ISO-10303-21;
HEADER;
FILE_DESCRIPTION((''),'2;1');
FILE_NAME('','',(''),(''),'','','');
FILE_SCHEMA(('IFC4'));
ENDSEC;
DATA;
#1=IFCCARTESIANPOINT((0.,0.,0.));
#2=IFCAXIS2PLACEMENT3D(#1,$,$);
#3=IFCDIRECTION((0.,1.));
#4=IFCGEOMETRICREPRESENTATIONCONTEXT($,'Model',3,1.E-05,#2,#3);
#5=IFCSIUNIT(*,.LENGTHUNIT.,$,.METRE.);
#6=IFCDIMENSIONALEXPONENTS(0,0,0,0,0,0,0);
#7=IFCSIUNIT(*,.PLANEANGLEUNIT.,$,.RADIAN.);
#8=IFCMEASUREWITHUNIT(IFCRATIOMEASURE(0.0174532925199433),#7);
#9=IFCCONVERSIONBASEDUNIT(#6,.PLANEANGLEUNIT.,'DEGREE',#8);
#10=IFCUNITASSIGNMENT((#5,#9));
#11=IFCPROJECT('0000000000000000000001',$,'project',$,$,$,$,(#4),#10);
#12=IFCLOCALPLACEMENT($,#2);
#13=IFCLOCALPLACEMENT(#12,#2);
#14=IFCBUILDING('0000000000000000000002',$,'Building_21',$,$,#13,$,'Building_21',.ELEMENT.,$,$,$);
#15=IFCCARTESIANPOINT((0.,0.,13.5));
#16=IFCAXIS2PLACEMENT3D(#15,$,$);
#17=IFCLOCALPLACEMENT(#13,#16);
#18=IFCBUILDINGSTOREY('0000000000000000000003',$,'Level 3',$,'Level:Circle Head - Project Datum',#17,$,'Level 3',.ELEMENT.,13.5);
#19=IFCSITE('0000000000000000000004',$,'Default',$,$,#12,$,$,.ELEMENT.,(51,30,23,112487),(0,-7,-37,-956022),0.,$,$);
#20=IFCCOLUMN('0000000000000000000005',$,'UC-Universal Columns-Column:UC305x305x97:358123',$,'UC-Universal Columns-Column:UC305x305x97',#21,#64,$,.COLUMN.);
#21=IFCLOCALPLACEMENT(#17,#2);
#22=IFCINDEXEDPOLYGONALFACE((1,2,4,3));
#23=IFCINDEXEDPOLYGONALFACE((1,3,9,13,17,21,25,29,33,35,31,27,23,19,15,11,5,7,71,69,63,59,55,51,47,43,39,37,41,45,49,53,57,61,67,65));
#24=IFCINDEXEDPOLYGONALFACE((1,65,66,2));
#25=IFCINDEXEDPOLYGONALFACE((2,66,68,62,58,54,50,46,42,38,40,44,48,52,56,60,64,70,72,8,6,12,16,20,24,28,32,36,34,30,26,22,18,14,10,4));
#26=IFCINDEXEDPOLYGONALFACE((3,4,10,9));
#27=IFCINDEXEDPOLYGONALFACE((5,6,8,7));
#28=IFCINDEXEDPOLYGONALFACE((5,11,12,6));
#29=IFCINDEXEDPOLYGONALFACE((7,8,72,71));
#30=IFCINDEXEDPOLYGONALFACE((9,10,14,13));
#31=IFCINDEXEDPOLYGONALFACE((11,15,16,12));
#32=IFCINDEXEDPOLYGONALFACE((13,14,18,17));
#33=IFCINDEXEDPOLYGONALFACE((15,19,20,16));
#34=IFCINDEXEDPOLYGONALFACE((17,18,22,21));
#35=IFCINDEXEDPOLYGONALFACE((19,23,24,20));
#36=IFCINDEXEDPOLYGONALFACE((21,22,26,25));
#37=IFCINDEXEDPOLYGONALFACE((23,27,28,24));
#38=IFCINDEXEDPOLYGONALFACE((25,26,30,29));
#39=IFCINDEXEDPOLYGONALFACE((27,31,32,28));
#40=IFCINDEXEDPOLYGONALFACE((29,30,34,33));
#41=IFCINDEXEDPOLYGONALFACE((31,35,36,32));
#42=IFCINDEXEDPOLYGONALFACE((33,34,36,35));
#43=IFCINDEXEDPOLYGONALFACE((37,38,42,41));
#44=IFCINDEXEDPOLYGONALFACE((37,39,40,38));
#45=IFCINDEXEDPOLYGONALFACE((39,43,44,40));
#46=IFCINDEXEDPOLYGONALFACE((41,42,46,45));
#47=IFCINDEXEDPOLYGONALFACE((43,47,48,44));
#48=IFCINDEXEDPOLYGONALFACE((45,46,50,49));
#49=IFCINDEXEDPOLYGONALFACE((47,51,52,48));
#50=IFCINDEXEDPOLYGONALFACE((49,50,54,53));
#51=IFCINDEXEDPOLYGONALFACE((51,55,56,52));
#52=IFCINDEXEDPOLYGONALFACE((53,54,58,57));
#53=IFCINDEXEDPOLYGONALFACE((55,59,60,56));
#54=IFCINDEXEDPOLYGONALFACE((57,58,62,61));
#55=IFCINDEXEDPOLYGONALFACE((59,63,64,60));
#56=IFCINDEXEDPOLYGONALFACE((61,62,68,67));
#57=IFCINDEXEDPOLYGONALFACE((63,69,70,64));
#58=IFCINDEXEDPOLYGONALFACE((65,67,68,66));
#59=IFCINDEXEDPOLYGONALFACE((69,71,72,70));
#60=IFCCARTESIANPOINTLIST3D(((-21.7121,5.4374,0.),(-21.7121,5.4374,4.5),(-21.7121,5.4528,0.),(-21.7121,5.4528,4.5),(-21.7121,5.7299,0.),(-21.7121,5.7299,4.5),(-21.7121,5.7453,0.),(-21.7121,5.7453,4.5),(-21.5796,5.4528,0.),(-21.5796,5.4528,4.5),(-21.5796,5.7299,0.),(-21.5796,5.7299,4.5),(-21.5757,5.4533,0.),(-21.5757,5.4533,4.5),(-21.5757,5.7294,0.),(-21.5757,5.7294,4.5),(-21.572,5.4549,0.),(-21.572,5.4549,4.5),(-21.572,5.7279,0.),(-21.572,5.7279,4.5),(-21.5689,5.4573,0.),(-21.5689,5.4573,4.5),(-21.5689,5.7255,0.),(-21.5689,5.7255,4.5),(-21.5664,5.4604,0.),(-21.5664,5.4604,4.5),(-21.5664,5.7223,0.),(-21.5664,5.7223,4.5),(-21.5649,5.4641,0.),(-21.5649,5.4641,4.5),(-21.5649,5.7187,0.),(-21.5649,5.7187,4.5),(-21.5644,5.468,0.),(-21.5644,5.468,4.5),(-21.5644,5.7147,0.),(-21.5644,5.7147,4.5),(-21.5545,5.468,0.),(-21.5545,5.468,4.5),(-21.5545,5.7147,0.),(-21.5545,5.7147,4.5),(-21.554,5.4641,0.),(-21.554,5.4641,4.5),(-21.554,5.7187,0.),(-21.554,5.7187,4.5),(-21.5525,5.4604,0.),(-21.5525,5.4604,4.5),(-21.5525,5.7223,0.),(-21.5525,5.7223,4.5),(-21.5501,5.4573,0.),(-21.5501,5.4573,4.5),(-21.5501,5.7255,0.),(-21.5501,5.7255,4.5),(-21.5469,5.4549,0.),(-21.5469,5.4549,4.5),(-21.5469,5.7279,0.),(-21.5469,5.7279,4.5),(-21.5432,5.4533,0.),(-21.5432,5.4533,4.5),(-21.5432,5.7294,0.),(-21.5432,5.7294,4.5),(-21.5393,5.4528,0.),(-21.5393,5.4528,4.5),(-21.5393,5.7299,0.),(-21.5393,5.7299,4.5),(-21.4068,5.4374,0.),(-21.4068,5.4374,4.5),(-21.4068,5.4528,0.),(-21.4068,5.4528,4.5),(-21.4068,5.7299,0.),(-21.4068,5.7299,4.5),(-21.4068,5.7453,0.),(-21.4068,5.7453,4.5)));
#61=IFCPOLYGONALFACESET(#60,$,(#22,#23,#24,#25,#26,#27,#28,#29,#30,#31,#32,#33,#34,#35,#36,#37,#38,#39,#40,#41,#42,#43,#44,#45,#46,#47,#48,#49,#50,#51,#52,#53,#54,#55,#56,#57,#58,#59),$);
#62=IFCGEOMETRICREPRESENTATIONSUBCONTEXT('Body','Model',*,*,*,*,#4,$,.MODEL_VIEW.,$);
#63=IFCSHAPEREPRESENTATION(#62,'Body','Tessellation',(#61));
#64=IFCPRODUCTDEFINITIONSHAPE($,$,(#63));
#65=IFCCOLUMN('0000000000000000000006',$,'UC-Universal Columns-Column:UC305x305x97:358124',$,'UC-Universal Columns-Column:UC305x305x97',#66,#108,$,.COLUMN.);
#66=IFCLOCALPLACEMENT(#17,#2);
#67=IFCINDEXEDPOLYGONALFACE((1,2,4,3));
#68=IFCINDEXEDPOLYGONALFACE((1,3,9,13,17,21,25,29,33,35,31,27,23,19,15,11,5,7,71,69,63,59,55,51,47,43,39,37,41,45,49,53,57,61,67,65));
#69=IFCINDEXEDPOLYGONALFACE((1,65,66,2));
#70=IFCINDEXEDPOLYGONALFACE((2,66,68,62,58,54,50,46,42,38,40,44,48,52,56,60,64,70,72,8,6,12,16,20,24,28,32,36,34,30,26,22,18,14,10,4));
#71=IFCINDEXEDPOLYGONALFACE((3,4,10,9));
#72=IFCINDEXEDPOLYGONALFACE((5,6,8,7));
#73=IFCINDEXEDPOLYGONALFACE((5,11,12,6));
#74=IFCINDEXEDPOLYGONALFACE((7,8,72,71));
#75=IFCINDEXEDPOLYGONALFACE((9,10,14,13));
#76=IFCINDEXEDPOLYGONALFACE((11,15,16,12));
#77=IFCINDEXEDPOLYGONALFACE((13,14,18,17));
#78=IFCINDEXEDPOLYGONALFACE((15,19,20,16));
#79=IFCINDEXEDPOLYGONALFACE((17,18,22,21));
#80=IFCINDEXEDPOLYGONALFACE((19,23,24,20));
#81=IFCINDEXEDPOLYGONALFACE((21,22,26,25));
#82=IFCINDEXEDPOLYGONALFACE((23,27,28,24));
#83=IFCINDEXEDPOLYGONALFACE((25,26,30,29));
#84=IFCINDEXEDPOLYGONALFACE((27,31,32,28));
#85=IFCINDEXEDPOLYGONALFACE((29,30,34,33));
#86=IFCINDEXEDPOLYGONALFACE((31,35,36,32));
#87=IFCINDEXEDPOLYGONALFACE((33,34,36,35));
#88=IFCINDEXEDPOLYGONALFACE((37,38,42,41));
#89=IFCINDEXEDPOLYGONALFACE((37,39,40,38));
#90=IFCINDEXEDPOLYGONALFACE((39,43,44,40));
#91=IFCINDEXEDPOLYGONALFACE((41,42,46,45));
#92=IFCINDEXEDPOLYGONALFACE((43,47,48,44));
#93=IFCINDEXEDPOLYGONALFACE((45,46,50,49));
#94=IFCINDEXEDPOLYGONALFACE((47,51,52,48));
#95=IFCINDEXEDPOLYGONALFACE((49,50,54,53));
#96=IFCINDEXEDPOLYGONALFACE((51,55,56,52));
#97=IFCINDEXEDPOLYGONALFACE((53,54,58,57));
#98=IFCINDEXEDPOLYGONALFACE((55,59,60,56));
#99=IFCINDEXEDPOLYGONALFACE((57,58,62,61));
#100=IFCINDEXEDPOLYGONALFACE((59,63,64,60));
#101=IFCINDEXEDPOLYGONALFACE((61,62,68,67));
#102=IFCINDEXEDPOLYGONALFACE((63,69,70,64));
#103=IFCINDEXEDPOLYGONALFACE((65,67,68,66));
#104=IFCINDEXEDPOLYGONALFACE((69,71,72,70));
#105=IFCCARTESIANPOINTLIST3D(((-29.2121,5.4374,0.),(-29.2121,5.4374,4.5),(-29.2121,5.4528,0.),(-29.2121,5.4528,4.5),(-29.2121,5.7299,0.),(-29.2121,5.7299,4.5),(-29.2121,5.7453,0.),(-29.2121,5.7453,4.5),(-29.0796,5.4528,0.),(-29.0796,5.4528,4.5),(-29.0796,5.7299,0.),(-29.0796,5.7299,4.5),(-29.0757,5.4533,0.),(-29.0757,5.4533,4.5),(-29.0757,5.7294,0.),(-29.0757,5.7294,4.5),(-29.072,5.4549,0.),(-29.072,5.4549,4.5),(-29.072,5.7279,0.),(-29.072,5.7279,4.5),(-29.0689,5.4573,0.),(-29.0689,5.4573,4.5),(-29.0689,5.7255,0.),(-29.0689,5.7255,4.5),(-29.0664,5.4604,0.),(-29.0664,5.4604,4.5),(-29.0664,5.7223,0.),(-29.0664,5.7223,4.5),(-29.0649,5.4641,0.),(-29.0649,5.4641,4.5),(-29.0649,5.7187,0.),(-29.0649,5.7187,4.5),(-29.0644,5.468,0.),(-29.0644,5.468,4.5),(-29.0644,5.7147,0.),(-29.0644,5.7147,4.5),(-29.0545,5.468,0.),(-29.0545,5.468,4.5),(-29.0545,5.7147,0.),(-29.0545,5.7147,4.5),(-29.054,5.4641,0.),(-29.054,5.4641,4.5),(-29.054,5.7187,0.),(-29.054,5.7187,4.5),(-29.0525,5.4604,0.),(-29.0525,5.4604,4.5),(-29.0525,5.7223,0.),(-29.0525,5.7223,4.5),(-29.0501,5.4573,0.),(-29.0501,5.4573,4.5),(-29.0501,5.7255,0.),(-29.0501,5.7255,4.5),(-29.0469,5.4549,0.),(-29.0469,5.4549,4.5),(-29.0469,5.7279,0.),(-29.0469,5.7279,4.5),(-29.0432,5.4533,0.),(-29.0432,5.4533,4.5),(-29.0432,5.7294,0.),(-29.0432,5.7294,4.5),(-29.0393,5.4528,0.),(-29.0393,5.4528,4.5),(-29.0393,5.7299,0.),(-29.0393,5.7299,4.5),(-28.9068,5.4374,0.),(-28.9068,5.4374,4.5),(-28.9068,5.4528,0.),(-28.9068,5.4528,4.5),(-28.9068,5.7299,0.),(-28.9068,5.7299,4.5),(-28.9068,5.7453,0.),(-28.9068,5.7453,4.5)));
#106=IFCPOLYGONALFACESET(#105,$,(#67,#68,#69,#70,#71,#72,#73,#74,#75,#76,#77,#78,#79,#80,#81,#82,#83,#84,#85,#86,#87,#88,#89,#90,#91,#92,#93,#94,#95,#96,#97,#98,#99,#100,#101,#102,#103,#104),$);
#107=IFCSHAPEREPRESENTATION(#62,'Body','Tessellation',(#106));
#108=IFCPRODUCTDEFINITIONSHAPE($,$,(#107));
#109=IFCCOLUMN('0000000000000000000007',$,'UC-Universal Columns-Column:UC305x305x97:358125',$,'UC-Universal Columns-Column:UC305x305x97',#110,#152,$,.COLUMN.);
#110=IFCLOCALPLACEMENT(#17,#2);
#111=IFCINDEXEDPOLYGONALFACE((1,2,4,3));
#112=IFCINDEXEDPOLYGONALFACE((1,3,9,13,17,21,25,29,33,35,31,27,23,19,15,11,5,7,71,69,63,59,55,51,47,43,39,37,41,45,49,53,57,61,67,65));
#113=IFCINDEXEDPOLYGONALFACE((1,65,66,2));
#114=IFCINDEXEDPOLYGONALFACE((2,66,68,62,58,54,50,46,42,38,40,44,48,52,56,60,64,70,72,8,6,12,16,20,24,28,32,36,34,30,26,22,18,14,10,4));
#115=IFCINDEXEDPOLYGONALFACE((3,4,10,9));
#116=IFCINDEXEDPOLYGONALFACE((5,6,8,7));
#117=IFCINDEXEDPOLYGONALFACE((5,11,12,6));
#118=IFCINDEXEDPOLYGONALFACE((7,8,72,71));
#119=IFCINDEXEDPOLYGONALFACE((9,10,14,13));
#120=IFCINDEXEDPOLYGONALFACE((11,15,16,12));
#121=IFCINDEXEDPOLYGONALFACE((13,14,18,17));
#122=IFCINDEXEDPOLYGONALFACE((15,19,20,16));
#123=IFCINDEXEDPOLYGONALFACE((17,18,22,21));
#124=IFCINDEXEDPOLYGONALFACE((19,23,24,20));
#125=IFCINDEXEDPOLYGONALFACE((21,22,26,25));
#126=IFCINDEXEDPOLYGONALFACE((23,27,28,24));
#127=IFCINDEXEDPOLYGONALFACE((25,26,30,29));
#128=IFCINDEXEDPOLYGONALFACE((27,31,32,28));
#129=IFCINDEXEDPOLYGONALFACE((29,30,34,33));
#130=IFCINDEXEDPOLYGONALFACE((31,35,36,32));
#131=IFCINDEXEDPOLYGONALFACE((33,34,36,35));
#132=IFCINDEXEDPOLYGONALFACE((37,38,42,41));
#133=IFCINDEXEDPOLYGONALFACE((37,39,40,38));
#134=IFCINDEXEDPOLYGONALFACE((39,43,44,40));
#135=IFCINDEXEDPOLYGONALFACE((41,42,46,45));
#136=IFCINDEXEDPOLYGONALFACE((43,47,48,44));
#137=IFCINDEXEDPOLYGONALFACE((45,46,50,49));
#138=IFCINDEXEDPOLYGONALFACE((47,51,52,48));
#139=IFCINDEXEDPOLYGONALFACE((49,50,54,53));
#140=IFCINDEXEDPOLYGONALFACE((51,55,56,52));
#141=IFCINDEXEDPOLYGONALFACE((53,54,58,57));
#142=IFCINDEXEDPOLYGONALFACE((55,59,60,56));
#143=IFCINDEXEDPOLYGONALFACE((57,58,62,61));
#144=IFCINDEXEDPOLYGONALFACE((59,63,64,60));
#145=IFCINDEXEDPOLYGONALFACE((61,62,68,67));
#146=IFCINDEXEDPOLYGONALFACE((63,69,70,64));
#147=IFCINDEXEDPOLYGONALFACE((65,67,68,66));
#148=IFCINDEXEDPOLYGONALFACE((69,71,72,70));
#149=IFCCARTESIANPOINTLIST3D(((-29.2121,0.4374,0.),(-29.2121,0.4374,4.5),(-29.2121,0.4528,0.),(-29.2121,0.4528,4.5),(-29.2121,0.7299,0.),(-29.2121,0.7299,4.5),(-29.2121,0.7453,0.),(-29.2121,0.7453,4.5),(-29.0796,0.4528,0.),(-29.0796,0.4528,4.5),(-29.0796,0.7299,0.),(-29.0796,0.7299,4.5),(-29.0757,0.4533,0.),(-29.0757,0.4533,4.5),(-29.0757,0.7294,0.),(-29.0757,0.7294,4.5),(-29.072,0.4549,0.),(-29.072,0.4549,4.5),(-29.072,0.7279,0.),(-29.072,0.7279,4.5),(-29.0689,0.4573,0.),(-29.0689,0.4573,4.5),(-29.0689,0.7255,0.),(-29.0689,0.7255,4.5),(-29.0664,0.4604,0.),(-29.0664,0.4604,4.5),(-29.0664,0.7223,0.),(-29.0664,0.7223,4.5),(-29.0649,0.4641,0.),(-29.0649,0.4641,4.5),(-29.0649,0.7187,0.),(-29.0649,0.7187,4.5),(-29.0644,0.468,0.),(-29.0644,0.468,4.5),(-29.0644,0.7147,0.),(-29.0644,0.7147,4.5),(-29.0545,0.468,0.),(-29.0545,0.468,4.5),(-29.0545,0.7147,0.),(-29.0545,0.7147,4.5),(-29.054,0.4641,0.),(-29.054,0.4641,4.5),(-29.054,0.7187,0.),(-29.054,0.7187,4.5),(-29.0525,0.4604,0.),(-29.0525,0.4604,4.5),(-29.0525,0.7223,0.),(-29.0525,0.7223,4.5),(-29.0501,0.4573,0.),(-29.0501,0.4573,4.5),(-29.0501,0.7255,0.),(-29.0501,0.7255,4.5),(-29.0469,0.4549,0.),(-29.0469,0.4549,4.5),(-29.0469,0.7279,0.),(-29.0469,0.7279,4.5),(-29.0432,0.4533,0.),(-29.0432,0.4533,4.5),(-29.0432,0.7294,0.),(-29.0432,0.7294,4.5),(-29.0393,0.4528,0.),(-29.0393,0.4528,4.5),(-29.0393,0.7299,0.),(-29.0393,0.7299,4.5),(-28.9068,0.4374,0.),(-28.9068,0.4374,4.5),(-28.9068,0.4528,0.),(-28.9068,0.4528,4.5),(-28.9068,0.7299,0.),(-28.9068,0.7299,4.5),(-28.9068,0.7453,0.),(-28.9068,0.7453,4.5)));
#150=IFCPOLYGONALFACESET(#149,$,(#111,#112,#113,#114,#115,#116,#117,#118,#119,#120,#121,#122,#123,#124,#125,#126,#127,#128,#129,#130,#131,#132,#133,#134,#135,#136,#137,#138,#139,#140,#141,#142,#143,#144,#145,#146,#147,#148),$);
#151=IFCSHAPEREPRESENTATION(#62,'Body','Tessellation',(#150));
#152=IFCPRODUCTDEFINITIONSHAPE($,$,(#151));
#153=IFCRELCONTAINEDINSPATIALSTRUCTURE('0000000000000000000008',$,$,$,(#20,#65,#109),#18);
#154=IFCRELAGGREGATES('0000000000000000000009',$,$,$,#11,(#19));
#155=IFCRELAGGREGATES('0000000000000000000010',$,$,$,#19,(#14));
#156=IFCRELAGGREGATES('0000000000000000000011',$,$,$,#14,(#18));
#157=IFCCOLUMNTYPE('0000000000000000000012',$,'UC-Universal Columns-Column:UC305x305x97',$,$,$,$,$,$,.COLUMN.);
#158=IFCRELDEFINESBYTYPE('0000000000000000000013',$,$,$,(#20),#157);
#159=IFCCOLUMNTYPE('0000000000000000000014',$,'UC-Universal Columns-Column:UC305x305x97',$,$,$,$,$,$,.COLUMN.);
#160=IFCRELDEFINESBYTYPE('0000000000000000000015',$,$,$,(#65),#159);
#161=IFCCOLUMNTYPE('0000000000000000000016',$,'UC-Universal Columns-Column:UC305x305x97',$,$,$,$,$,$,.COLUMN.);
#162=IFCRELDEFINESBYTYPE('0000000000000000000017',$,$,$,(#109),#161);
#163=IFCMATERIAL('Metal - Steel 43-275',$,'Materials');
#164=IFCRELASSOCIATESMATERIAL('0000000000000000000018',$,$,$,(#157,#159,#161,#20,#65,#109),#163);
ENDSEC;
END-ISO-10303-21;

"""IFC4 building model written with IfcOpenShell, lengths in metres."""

from ifc_helpers import new_model, entity, si_unit, converted_unit, direction, frame, frame_2d, origin, place, context, subcontext, project, spatial, polyline, circle_curve, parameter, trimmed, segment, composite_curve, i_section, outline, extrude, source, transform, mapped, material, material_profile, profile_set, profile_usage, type_object, type_shapes, element, save


model = new_model("IFC4")

# Units and contexts
model_context = context("Model", 3, precision=1e-05, world=origin(), true_north=direction((0.0, 1.0)))
body_context = subcontext(model_context, "Body", "Model", "MODEL_VIEW")
ifc_project = project(units=[si_unit("LENGTHUNIT", "METRE"), converted_unit("PLANEANGLEUNIT", "DEGREE", entity("IfcRatioMeasure", 0.0174532925199433), si_unit("PLANEANGLEUNIT", "RADIAN"), dimensions=[0, 0, 0, 0, 0, 0, 0])], contexts=[model_context])

# Site, building, storey
site_placement = place(None, origin())
site = spatial("IfcSite", under=ifc_project, at=site_placement, Name="Default", CompositionType="ELEMENT", RefLatitude=(51, 30, 23, 112487), RefLongitude=(0, -7, -37, -956022), RefElevation=0.0)
building_placement = place(site_placement, origin())
building = spatial("IfcBuilding", under=site, at=building_placement, Name="Building_21", LongName="Building_21", CompositionType="ELEMENT")
storey_placement = place(building_placement, frame((0.0, 0.0, 13.5)))
storey = spatial("IfcBuildingStorey", under=building, at=storey_placement, Name="Level 3", ObjectType="Level:Circle Head - Project Datum", LongName="Level 3", CompositionType="ELEMENT", Elevation=13.5)

# Columns
ifc_material_1 = material(Name="Metal - Steel 43-275", Category="Materials")
ifc_material_profile_1 = material_profile(ifc_material_1, outline(composite_curve([segment(polyline([(-0.1527, 0.154, 0.0), (0.1527, 0.154, 0.0)]), True, "CONTINUOUS"), segment(polyline([(0.1527, 0.154, 0.0), (0.1527, 0.1386, 0.0)]), True, "CONTINUOUS"), segment(polyline([(0.1527, 0.1386, 0.0), (0.0201, 0.1386, 0.0)]), True, "CONTINUOUS"), segment(trimmed(circle_curve(frame((0.0201, 0.1234, 0.0)), 0.0152), [parameter(90.0)], [parameter(180.0)], True, "PARAMETER"), True, "CONTINUOUS"), segment(polyline([(0.0049, 0.1234, 0.0), (0.0049, -0.1234, 0.0)]), True, "CONTINUOUS"), segment(trimmed(circle_curve(frame((0.0201, -0.1234, 0.0)), 0.0152), [parameter(180.0)], [parameter(270.0)], True, "PARAMETER"), True, "CONTINUOUS"), segment(polyline([(0.0201, -0.1386, 0.0), (0.1527, -0.1386, 0.0)]), True, "CONTINUOUS"), segment(polyline([(0.1527, -0.1386, 0.0), (0.1527, -0.154, 0.0)]), True, "CONTINUOUS"), segment(polyline([(0.1527, -0.154, 0.0), (-0.1527, -0.154, 0.0)]), True, "CONTINUOUS"), segment(polyline([(-0.1527, -0.154, 0.0), (-0.1527, -0.1386, 0.0)]), True, "CONTINUOUS"), segment(polyline([(-0.1527, -0.1386, 0.0), (-0.0201, -0.1386, 0.0)]), True, "CONTINUOUS"), segment(trimmed(circle_curve(frame((-0.0201, -0.1234, 0.0)), 0.0152), [parameter(270.0)], [parameter(0.0)], True, "PARAMETER"), True, "CONTINUOUS"), segment(polyline([(-0.0049, -0.1234, 0.0), (-0.005, 0.1234, 0.0)]), True, "CONTINUOUS"), segment(trimmed(circle_curve(frame((-0.0201, 0.1234, 0.0)), 0.0152), [parameter(0.0)], [parameter(90.0)], True, "PARAMETER"), True, "CONTINUOUS"), segment(polyline([(-0.0201, 0.1386, 0.0), (-0.1527, 0.1386, 0.0)]), True, "CONTINUOUS"), segment(polyline([(-0.1527, 0.1386, 0.0), (-0.1527, 0.154, 0.0)]), True, "CONTINUOUS")], self_intersect=False), kind="CURVE"), Name="UC305x305x97")
ifc_material_profile_2 = material_profile(ifc_material_1, outline(composite_curve([segment(polyline([(0.1527, 0.154, 0.0), (0.1527, 0.1386, 0.0)]), True, "CONTINUOUS"), segment(polyline([(0.1527, 0.1386, 0.0), (0.0049, 0.1386, 0.0)]), True, "CONTINUOUS"), segment(polyline([(0.0049, 0.1386, 0.0), (0.0049, -0.1386, 0.0)]), True, "CONTINUOUS"), segment(polyline([(0.0049, -0.1386, 0.0), (0.1527, -0.1386, 0.0)]), True, "CONTINUOUS"), segment(polyline([(0.1527, -0.1386, 0.0), (0.1527, -0.154, 0.0)]), True, "CONTINUOUS"), segment(polyline([(0.1527, -0.154, 0.0), (-0.1527, -0.154, 0.0)]), True, "CONTINUOUS"), segment(polyline([(-0.1527, -0.154, 0.0), (-0.1527, -0.1386, 0.0)]), True, "CONTINUOUS"), segment(polyline([(-0.1527, -0.1386, 0.0), (-0.005, -0.1386, 0.0)]), True, "CONTINUOUS"), segment(polyline([(-0.005, -0.1386, 0.0), (-0.005, 0.1386, 0.0)]), True, "CONTINUOUS"), segment(polyline([(-0.005, 0.1386, 0.0), (-0.1527, 0.1386, 0.0)]), True, "CONTINUOUS"), segment(polyline([(-0.1527, 0.1386, 0.0), (-0.1527, 0.154, 0.0)]), True, "CONTINUOUS"), segment(polyline([(-0.1527, 0.154, 0.0), (0.1527, 0.154, 0.0)]), True, "CONTINUOUS")], self_intersect=False), kind="CURVE"), Name="UC305x305x97")
ifc_profile_set = profile_set([ifc_material_profile_1, ifc_material_profile_2], Name="UC305x305x97")
ifc_profile_usage_1 = profile_usage(ifc_profile_set)
column_type_1 = type_object("IfcColumnType", Name="UC-Universal Columns-Column:UC305x305x97", PredefinedType="COLUMN", material=ifc_profile_set)
shared_shape_1 = source(origin(), body_context, "Body", "SweptSolid", [
    extrude(i_section(OverallWidth=0.3053, OverallDepth=0.3079, WebThickness=0.0099, FlangeThickness=0.0154, FilletRadius=0.0152, at=frame_2d((0.0, 0.0), x_axis=(0.0, 1.0))), frame((-21.5595, 5.5914, 13.5), z_axis=(0.0, 0.0, 1.0), x_axis=(0.0, -1.0, 0.0)), (0.0, 0.0, 1.0), 4.5),
])
type_shapes(column_type_1, [shared_shape_1])
column_1_placement = place(storey_placement, frame((0.0, 0.0, -13.5)))
element("IfcColumn", 1, at=column_1_placement, inside=storey, type_object=column_type_1, material=ifc_profile_usage_1, Name="UC-Universal Columns-Column:UC305x305x97:358123", ObjectType="UC-Universal Columns-Column:UC305x305x97", PredefinedType="COLUMN", context=body_context, shape_type="MappedRepresentation", body=[
    mapped(shared_shape_1, transform((0.0, 0.0, 0.0), scale=1.0)),
])
ifc_profile_usage_2 = profile_usage(ifc_profile_set)
column_type_2 = type_object("IfcColumnType", Name="UC-Universal Columns-Column:UC305x305x97", PredefinedType="COLUMN", material=ifc_profile_set)
shared_shape_2 = source(origin(), body_context, "Body", "SweptSolid", [
    extrude(i_section(OverallWidth=0.3053, OverallDepth=0.3079, WebThickness=0.0099, FlangeThickness=0.0154, FilletRadius=0.0152, at=frame_2d((0.0, 0.0), x_axis=(0.0, 1.0))), frame((-29.0595, 5.5914, 13.5), z_axis=(0.0, 0.0, 1.0), x_axis=(0.0, -1.0, 0.0)), (0.0, 0.0, 1.0), 4.5),
])
type_shapes(column_type_2, [shared_shape_2])
column_2_placement = place(storey_placement, frame((0.0, 0.0, -13.5)))
element("IfcColumn", 2, at=column_2_placement, inside=storey, type_object=column_type_2, material=ifc_profile_usage_2, Name="UC-Universal Columns-Column:UC305x305x97:358124", ObjectType="UC-Universal Columns-Column:UC305x305x97", PredefinedType="COLUMN", context=body_context, shape_type="MappedRepresentation", body=[
    mapped(shared_shape_2, transform((0.0, 0.0, 0.0), scale=1.0)),
])
ifc_profile_usage_3 = profile_usage(ifc_profile_set)
column_type_3 = type_object("IfcColumnType", Name="UC-Universal Columns-Column:UC305x305x97", PredefinedType="COLUMN", material=ifc_profile_set)
shared_shape_3 = source(origin(), body_context, "Body", "SweptSolid", [
    extrude(i_section(OverallWidth=0.3053, OverallDepth=0.3079, WebThickness=0.0099, FlangeThickness=0.0154, FilletRadius=0.0152, at=frame_2d((0.0, 0.0), x_axis=(0.0, 1.0))), frame((-29.0595, 0.5914, 13.5), z_axis=(0.0, 0.0, 1.0), x_axis=(0.0, -1.0, 0.0)), (0.0, 0.0, 1.0), 4.5),
])
type_shapes(column_type_3, [shared_shape_3])
column_3_placement = place(storey_placement, frame((0.0, 0.0, -13.5)))
element("IfcColumn", 3, at=column_3_placement, inside=storey, type_object=column_type_3, material=ifc_profile_usage_3, Name="UC-Universal Columns-Column:UC305x305x97:358125", ObjectType="UC-Universal Columns-Column:UC305x305x97", PredefinedType="COLUMN", context=body_context, shape_type="MappedRepresentation", body=[
    mapped(shared_shape_3, transform((0.0, 0.0, 0.0), scale=1.0)),
])

save(model, "model.ifc")
